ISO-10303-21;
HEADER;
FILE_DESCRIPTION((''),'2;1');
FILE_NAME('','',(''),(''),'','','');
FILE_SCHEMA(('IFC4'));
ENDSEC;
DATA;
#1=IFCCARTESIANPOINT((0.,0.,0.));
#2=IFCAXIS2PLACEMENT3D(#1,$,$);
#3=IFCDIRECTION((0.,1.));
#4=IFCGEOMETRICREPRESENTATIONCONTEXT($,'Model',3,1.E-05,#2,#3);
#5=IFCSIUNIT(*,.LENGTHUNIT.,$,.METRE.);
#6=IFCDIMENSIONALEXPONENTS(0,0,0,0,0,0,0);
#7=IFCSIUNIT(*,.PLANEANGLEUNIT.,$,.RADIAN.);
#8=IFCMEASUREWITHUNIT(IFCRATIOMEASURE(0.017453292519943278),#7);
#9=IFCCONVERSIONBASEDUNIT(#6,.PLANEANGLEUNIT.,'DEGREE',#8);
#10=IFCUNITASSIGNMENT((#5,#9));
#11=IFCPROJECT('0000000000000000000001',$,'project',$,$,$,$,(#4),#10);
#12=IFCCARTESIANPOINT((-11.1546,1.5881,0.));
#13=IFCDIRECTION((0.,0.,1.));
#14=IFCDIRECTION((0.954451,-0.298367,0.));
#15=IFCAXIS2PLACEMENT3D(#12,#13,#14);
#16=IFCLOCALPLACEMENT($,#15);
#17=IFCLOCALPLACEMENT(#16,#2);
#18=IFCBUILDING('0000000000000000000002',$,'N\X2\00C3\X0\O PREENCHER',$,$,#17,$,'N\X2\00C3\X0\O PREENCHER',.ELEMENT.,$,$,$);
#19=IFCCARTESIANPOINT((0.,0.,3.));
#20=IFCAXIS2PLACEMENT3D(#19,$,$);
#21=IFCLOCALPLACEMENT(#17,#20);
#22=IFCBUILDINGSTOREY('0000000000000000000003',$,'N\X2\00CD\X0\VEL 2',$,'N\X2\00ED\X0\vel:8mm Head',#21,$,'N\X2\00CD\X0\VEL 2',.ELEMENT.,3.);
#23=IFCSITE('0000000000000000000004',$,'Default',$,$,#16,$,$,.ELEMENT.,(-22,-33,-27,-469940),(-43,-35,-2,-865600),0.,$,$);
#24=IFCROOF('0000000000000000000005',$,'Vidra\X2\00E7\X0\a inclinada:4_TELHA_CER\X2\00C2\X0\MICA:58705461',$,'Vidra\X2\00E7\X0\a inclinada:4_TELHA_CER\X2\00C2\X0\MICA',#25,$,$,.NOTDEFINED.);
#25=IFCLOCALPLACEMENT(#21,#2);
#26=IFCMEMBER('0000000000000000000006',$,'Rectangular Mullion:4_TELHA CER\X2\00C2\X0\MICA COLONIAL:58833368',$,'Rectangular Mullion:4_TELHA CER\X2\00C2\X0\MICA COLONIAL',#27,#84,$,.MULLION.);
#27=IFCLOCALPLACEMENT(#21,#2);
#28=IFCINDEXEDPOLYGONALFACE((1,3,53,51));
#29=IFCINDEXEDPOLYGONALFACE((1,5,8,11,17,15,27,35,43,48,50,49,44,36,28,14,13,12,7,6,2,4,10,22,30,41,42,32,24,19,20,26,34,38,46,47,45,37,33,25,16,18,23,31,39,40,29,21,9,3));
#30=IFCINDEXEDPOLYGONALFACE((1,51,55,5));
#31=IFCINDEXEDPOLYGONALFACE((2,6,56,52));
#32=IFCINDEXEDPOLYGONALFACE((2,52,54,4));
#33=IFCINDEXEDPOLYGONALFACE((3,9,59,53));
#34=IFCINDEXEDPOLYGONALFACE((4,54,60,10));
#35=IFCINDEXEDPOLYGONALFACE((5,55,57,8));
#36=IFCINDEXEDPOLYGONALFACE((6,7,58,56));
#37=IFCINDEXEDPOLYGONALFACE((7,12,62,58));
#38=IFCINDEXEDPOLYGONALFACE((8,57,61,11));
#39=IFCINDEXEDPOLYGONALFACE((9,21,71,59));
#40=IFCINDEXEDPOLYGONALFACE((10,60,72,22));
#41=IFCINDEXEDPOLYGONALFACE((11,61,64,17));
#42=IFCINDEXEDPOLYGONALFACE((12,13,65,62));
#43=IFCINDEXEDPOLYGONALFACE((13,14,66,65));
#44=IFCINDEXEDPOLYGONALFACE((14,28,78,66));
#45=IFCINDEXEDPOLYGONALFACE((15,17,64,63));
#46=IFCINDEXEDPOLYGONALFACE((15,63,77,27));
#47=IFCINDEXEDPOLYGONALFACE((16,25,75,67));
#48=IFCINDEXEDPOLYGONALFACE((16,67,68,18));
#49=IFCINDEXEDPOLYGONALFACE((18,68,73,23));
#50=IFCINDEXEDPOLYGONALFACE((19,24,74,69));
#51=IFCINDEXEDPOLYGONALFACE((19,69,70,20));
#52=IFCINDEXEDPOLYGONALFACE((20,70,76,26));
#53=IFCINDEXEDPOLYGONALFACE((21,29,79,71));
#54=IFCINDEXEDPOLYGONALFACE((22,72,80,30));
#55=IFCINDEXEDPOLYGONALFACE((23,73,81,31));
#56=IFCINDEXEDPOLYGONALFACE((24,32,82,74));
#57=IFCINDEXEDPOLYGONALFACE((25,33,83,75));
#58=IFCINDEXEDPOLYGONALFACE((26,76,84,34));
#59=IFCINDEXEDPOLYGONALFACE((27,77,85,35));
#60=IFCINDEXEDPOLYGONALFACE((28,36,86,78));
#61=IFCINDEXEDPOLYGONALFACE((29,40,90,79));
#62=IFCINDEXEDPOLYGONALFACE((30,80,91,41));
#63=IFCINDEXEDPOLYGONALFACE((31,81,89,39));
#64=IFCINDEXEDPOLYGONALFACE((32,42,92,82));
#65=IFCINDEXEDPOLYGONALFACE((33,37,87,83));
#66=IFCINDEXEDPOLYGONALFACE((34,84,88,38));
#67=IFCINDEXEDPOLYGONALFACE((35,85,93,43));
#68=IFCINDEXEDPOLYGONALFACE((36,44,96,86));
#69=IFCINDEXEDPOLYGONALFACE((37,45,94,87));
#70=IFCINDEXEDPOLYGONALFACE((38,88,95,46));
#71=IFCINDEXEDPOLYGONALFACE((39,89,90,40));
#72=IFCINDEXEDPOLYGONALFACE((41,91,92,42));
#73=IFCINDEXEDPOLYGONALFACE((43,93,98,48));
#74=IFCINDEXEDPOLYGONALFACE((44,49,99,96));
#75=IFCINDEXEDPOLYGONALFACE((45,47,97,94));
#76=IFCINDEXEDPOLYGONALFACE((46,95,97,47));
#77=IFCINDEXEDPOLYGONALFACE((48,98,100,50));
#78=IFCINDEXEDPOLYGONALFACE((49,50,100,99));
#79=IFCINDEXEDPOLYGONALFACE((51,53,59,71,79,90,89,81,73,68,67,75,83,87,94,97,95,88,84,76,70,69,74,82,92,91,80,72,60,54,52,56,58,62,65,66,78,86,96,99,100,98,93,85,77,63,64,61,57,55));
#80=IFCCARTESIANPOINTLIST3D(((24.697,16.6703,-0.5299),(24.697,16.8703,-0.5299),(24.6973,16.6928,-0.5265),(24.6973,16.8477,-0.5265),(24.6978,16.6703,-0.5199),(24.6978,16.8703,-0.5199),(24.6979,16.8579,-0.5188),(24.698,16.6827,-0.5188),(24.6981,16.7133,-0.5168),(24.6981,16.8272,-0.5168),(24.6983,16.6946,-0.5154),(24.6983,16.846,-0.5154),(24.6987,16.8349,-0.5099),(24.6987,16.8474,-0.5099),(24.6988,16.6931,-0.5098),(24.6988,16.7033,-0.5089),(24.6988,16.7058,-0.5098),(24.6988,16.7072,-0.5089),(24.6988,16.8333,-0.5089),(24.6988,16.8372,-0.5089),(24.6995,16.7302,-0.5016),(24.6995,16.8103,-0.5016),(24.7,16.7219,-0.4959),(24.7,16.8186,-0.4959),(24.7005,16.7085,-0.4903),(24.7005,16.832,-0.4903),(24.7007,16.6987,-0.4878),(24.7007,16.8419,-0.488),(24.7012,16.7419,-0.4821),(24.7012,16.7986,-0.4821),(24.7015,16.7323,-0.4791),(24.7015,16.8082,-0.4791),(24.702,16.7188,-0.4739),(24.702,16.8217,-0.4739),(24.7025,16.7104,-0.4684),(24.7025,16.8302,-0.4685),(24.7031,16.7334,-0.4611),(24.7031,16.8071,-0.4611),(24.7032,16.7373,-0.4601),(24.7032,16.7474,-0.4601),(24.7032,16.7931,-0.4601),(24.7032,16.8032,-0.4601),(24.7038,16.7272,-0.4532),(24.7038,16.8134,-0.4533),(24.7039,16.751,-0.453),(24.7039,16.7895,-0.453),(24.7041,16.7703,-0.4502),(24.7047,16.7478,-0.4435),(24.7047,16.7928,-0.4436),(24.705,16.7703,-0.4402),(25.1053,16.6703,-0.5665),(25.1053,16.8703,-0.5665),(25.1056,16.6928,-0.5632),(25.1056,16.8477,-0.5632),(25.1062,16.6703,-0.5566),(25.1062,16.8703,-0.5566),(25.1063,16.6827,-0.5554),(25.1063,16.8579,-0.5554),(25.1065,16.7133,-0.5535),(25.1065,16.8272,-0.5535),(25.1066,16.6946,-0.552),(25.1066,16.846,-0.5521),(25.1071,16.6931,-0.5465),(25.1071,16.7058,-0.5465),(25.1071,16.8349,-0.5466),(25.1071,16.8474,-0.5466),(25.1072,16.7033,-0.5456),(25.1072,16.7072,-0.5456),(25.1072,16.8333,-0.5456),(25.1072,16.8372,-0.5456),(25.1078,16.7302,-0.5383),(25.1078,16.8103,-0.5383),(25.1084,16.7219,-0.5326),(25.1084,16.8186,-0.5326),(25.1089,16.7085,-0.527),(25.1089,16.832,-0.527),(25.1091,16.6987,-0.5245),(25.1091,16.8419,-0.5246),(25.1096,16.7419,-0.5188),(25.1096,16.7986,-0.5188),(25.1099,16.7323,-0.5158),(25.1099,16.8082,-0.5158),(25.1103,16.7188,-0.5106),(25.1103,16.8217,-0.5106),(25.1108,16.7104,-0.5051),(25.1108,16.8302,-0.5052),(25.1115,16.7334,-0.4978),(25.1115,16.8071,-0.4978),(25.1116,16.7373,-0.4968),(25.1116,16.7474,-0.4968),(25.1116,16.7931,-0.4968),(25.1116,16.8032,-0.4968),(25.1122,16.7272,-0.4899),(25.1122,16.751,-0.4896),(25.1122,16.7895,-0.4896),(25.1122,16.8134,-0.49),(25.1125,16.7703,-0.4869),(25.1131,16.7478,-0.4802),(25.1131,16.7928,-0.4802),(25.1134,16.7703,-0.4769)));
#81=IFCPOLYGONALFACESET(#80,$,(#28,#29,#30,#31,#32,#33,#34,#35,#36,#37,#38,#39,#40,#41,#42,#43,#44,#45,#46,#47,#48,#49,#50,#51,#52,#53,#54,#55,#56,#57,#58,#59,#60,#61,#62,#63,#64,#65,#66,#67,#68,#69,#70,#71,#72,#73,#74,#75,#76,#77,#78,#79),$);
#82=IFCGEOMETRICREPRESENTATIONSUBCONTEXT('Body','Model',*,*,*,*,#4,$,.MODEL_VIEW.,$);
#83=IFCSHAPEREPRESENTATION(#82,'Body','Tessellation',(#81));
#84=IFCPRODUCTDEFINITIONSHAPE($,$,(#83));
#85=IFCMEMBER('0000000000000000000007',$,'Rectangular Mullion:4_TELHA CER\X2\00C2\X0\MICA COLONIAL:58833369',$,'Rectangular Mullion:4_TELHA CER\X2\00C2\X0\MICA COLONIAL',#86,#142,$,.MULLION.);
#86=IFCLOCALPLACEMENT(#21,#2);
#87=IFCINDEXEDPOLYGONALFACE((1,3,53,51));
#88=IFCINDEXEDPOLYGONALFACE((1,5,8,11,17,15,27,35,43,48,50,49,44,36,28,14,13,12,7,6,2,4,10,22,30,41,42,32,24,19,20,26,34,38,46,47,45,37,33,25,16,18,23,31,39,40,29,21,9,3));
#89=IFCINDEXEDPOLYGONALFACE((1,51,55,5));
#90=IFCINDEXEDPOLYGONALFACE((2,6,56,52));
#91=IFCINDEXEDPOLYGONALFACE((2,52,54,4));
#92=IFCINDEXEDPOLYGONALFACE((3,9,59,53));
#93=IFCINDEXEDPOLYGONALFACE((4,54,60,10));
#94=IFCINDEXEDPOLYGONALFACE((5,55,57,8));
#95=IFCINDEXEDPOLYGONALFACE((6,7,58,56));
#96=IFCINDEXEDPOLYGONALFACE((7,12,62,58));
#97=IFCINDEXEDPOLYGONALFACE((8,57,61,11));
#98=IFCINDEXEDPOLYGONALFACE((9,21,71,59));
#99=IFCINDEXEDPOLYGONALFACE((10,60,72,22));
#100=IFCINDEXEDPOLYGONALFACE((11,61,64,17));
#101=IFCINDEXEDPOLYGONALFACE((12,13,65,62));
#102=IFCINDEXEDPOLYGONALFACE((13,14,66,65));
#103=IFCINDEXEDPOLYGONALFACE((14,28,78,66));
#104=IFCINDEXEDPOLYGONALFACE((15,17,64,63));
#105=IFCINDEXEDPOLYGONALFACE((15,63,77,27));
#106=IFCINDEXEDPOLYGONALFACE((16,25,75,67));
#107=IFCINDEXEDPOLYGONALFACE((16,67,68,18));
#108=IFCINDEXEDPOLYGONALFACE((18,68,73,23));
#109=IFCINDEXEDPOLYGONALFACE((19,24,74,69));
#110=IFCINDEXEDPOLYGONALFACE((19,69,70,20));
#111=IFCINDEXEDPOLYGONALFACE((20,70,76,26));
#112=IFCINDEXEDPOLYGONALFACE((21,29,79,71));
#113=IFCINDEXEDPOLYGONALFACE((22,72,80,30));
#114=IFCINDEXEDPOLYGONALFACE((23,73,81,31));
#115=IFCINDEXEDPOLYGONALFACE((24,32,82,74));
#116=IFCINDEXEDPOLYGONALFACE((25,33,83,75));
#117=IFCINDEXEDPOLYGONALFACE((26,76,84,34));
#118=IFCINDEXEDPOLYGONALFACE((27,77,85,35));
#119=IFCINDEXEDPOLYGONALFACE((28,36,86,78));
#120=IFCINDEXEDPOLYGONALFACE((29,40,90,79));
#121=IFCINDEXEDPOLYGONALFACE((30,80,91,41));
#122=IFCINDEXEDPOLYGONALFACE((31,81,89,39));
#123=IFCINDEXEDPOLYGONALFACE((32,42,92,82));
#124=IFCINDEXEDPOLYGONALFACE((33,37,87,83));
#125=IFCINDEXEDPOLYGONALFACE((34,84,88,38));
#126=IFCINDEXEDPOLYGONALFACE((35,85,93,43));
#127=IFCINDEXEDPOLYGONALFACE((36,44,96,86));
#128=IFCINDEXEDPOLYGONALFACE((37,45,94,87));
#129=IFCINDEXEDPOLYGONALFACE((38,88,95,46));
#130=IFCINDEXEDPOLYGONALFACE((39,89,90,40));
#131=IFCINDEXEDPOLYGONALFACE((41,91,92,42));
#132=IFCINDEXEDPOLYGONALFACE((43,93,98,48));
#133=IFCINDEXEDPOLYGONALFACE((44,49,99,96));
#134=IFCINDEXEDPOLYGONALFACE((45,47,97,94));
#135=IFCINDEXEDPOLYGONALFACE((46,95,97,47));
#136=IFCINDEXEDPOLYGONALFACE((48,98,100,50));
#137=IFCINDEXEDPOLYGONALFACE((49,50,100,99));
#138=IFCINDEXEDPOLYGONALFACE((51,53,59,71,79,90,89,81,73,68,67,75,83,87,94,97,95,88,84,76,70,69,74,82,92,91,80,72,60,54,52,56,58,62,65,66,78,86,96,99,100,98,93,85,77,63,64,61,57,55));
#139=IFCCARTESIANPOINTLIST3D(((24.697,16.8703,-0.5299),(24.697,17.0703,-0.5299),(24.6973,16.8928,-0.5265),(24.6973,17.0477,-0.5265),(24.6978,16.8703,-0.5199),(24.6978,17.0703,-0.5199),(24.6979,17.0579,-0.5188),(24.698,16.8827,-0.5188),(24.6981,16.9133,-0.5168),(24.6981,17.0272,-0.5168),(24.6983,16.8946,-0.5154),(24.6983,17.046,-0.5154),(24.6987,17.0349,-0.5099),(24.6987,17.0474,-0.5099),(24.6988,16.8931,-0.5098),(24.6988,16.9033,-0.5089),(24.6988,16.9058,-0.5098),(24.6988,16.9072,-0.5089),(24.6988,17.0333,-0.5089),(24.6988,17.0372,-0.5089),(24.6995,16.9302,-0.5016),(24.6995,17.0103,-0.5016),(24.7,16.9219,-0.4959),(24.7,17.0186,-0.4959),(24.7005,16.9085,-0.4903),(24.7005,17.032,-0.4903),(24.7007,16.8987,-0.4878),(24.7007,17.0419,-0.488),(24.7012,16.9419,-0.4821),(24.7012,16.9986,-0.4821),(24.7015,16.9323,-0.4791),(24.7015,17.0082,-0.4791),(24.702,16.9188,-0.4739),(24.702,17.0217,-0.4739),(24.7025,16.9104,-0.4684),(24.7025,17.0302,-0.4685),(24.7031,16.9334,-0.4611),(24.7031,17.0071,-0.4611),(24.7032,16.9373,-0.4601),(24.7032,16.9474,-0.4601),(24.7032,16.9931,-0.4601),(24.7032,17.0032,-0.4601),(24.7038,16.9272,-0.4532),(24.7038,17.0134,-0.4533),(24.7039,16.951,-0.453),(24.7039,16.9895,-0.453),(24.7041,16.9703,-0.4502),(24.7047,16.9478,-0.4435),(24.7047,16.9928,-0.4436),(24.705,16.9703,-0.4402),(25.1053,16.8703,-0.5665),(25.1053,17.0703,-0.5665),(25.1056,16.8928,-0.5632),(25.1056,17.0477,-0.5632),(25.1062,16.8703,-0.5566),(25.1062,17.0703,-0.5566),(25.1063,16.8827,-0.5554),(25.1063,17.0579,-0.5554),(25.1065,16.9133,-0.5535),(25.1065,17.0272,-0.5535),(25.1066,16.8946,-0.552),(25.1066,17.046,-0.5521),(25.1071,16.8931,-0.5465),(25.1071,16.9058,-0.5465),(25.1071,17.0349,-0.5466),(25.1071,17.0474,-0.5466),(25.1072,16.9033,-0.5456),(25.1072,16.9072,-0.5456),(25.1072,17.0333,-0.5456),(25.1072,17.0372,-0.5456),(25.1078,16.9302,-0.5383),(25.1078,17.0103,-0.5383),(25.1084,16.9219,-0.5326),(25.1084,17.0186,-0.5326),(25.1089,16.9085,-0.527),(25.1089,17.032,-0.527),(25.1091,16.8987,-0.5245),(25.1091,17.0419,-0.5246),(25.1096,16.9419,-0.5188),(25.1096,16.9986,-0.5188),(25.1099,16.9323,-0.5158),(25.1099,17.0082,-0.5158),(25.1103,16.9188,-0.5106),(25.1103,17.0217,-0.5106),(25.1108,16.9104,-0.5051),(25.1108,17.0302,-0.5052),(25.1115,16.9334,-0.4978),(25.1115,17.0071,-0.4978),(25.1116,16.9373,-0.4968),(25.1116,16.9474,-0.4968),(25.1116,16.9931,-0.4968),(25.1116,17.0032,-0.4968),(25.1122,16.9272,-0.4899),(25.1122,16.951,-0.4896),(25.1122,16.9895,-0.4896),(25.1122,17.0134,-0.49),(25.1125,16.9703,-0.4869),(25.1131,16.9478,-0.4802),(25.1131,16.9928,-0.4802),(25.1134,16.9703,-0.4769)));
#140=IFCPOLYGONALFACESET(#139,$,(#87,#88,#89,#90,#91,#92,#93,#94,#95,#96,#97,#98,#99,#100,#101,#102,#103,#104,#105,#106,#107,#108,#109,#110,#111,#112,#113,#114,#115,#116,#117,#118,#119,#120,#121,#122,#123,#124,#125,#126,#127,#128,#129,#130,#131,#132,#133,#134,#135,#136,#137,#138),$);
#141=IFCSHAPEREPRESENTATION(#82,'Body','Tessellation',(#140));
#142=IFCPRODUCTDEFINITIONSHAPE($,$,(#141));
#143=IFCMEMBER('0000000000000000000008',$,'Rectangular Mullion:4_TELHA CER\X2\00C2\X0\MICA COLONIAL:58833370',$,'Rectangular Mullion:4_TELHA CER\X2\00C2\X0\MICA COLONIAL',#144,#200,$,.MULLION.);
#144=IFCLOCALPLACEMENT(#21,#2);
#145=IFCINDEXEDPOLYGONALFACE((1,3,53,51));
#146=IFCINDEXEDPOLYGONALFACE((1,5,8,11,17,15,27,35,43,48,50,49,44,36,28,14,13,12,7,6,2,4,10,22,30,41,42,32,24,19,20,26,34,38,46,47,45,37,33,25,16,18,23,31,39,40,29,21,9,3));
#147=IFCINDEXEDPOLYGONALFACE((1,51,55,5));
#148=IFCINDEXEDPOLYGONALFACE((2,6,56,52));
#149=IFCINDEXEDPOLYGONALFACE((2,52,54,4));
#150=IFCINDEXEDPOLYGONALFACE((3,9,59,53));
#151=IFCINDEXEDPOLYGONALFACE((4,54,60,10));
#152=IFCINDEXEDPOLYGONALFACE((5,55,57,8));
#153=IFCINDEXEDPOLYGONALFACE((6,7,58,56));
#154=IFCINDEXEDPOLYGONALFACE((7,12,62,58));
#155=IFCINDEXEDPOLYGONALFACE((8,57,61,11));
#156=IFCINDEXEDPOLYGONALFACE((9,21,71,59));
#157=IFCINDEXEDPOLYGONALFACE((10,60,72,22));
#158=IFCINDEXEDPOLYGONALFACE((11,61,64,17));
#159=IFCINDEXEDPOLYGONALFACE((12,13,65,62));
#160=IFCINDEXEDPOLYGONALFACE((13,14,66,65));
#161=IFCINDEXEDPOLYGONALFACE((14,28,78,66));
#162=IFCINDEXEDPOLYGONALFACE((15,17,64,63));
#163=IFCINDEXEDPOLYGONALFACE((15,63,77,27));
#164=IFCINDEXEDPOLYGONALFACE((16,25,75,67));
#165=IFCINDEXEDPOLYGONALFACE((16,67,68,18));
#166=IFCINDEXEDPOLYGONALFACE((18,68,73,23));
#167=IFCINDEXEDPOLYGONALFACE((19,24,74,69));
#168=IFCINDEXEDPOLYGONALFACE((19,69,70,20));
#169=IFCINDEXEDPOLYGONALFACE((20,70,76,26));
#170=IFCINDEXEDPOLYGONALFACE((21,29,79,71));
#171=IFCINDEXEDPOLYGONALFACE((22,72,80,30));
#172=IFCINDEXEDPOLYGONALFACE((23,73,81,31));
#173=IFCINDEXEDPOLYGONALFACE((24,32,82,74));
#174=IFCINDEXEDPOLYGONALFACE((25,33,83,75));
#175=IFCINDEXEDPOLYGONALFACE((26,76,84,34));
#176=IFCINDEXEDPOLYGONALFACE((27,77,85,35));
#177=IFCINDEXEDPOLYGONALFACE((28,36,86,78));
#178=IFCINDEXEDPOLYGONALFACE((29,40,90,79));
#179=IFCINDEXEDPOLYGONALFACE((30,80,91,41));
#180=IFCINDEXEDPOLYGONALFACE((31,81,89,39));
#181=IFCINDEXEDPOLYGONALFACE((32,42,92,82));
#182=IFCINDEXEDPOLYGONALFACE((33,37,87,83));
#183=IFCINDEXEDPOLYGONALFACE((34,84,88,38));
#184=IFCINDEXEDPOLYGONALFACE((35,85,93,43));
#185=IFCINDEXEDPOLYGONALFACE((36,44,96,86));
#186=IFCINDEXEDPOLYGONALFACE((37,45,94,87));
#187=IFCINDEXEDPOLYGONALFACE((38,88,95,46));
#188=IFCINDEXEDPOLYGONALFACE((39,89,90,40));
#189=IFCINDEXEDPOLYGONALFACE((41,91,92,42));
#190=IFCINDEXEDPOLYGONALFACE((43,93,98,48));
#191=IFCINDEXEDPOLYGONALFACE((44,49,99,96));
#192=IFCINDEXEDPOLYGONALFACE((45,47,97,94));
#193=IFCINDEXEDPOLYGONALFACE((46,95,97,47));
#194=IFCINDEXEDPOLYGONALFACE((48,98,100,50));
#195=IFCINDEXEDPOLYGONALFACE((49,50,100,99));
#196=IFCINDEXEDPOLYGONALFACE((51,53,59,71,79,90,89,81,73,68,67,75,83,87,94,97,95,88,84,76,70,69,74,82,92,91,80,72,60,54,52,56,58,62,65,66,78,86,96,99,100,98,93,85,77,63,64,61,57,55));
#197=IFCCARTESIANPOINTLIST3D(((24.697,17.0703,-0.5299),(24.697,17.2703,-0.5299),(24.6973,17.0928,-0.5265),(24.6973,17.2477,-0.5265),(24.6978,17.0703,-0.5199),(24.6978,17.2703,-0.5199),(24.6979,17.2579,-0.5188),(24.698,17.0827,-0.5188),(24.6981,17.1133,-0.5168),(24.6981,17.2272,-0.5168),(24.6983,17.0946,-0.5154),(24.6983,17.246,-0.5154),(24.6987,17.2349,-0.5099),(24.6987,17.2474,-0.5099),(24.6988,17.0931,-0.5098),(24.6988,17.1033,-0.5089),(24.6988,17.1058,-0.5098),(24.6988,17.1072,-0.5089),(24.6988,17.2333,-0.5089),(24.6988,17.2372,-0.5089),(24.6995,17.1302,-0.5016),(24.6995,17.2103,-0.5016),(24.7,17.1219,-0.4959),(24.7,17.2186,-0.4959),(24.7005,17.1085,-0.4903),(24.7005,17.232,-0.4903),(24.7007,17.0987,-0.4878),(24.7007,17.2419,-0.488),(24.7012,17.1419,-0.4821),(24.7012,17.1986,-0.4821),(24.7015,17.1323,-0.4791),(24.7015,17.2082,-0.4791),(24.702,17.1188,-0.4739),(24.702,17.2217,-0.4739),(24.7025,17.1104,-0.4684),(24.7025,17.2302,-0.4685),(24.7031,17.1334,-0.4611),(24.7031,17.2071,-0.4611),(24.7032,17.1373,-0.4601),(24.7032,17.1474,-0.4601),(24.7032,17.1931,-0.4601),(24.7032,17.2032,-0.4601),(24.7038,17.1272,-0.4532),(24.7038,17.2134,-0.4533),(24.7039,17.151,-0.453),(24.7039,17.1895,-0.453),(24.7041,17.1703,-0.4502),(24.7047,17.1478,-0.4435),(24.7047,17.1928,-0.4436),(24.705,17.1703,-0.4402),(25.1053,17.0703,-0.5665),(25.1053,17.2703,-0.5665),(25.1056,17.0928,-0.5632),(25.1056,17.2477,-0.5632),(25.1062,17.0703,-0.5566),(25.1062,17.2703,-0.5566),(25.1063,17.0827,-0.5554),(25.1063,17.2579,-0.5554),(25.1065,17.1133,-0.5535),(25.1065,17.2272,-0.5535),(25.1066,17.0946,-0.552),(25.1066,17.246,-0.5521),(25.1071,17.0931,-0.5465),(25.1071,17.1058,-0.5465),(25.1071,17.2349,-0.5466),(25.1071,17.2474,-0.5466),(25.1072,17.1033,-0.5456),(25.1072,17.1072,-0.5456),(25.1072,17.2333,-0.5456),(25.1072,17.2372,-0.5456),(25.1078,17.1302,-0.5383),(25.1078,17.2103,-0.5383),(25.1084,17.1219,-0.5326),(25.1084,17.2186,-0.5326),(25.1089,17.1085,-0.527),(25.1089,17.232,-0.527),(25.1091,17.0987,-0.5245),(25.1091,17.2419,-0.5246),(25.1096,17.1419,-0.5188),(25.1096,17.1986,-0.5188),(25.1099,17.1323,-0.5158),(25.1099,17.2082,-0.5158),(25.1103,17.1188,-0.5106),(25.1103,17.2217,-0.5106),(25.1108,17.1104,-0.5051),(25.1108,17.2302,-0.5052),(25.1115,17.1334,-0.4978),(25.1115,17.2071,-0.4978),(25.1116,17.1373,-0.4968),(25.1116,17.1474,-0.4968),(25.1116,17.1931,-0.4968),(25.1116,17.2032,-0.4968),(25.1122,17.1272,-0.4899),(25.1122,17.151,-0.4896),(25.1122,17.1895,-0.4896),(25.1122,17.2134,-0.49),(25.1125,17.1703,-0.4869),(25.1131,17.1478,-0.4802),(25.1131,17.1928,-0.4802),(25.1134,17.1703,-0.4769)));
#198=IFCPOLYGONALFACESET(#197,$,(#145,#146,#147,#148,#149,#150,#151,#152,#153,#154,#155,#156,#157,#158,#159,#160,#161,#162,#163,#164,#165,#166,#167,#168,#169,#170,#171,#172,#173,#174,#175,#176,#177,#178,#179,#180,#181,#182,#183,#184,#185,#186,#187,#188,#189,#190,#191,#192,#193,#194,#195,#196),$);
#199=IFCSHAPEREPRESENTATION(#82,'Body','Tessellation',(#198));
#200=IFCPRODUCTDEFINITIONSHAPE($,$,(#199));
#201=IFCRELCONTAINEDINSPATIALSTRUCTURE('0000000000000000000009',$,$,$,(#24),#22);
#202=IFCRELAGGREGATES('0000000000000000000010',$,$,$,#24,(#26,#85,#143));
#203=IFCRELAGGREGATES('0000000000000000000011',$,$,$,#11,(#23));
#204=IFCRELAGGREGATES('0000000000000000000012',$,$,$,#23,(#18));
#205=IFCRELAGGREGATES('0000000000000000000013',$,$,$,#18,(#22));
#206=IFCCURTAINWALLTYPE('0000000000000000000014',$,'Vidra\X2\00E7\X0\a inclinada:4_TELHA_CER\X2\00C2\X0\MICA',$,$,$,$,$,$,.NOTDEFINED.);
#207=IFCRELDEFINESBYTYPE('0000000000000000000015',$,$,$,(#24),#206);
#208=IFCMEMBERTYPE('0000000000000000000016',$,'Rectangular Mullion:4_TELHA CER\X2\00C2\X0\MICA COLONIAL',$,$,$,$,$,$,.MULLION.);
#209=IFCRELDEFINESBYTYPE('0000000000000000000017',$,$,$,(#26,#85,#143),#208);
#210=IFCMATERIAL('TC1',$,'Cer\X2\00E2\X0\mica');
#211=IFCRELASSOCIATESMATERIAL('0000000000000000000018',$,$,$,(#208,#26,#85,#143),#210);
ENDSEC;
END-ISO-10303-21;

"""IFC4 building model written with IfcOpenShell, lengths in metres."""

from ifc_helpers import new_model, entity, si_unit, converted_unit, direction, frame, origin, place, context, subcontext, project, spatial, line, arc, indexed_curve, outline, extrude, source, transform, mapped, material, type_object, type_shapes, element, aggregate, save


model = new_model("IFC4")

# Units and contexts
model_context = context("Model", 3, precision=1e-05, world=origin(), true_north=direction((0.0, 1.0)))
body_context = subcontext(model_context, "Body", "Model", "MODEL_VIEW")
ifc_project = project(units=[si_unit("LENGTHUNIT", "METRE"), converted_unit("PLANEANGLEUNIT", "DEGREE", entity("IfcRatioMeasure", 0.017453292519943278), si_unit("PLANEANGLEUNIT", "RADIAN"), dimensions=[0, 0, 0, 0, 0, 0, 0])], contexts=[model_context])

# Site, building, storey
site_placement = place(None, frame((-11.1546, 1.5881, 0.0), z_axis=(0.0, 0.0, 1.0), x_axis=(0.954451, -0.298367, 0.0)))
site = spatial("IfcSite", under=ifc_project, at=site_placement, Name="Default", CompositionType="ELEMENT", RefLatitude=(-22, -33, -27, -469940), RefLongitude=(-43, -35, -2, -865600), RefElevation=0.0)
building_placement = place(site_placement, origin())
building = spatial("IfcBuilding", under=site, at=building_placement, Name="NÃO PREENCHER", LongName="NÃO PREENCHER", CompositionType="ELEMENT")
storey_placement = place(building_placement, frame((0.0, 0.0, 3.0)))
storey = spatial("IfcBuildingStorey", under=building, at=storey_placement, Name="NÍVEL 2", ObjectType="Nível:8mm Head", LongName="NÍVEL 2", CompositionType="ELEMENT", Elevation=3.0)

# Roof, members
curtain_wall_type = type_object("IfcCurtainWallType", Name="Vidraça inclinada:4_TELHA_CERÂMICA", PredefinedType="NOTDEFINED")
roof_placement = place(storey_placement, frame((0.0, 0.0, -3.0)))
roof = element("IfcRoof", 1, at=roof_placement, inside=storey, type_object=curtain_wall_type, Name="Vidraça inclinada:4_TELHA_CERÂMICA:58705461", ObjectType="Vidraça inclinada:4_TELHA_CERÂMICA", PredefinedType="NOTDEFINED")
ifc_material = material(Name="TC1", Category="Cerâmica")
member_type = type_object("IfcMemberType", Name="Rectangular Mullion:4_TELHA CERÂMICA COLONIAL", PredefinedType="MULLION", material=ifc_material)
shared_shape = source(origin(), body_context, "Body", "SweptSolid", [
    extrude(outline(indexed_curve([(-0.029, -0.1), (-0.019, -0.1), (-0.0164, -0.0815), (-0.0089, -0.0645), (-0.0089, -0.0771), (0.061, 0.0), (-0.009, 0.0771), (-0.009, 0.0646), (-0.0165, 0.0816), (-0.019, 0.1), (-0.029, 0.1), (-0.0089, 0.0479), (0.041, 0.0229), (0.041, 0.0329), (0.0131, 0.0425), (-0.008, 0.0631), (-0.008, 0.067), (0.051, 0.0), (-0.008, -0.067), (-0.008, -0.0631), (0.0131, -0.0425), (0.041, -0.0329), (0.041, -0.0229), (-0.0089, -0.0479)], segments=[line(1, 2), arc(2, 3, 4), line(4, 5), arc(5, 6, 7), line(7, 8), arc(8, 9, 10), line(10, 11), arc(11, 12, 13), line(13, 14), arc(14, 15, 16), line(16, 17), arc(17, 18, 19), line(19, 20), arc(20, 21, 22), line(22, 23), arc(23, 24, 1)], self_intersect=False)), frame((0.0, -0.029, -0.41), z_axis=(0.0, 0.0, 1.0), x_axis=(0.0, -1.0, 0.0)), (0.0, 0.0, 1.0), 0.41),
])
type_shapes(member_type, [shared_shape])
member_1_placement = place(roof_placement, frame((24.697, 16.7703, 2.4701), z_axis=(-0.99599, 0.0, 0.089469), x_axis=(0.0, 1.0, 0.0)))
member_1 = element("IfcMember", 2, at=member_1_placement, type_object=member_type, material=ifc_material, Name="Rectangular Mullion:4_TELHA CERÂMICA COLONIAL:58833368", ObjectType="Rectangular Mullion:4_TELHA CERÂMICA COLONIAL", PredefinedType="MULLION", context=body_context, shape_type="MappedRepresentation", body=[
    mapped(shared_shape, transform((0.0, 0.0, 0.0), scale=1.0)),
])
member_2_placement = place(roof_placement, frame((24.697, 16.9703, 2.4701), z_axis=(-0.99599, 0.0, 0.089469), x_axis=(0.0, 1.0, 0.0)))
member_2 = element("IfcMember", 3, at=member_2_placement, type_object=member_type, material=ifc_material, Name="Rectangular Mullion:4_TELHA CERÂMICA COLONIAL:58833369", ObjectType="Rectangular Mullion:4_TELHA CERÂMICA COLONIAL", PredefinedType="MULLION", context=body_context, shape_type="MappedRepresentation", body=[
    mapped(shared_shape, transform((0.0, 0.0, 0.0), scale=1.0)),
])
member_3_placement = place(roof_placement, frame((24.697, 17.1703, 2.4701), z_axis=(-0.99599, 0.0, 0.089469), x_axis=(0.0, 1.0, 0.0)))
member_3 = element("IfcMember", 4, at=member_3_placement, type_object=member_type, material=ifc_material, Name="Rectangular Mullion:4_TELHA CERÂMICA COLONIAL:58833370", ObjectType="Rectangular Mullion:4_TELHA CERÂMICA COLONIAL", PredefinedType="MULLION", context=body_context, shape_type="MappedRepresentation", body=[
    mapped(shared_shape, transform((0.0, 0.0, 0.0), scale=1.0)),
])
aggregate(roof, [member_1, member_2, member_3])

save(model, "model.ifc")
